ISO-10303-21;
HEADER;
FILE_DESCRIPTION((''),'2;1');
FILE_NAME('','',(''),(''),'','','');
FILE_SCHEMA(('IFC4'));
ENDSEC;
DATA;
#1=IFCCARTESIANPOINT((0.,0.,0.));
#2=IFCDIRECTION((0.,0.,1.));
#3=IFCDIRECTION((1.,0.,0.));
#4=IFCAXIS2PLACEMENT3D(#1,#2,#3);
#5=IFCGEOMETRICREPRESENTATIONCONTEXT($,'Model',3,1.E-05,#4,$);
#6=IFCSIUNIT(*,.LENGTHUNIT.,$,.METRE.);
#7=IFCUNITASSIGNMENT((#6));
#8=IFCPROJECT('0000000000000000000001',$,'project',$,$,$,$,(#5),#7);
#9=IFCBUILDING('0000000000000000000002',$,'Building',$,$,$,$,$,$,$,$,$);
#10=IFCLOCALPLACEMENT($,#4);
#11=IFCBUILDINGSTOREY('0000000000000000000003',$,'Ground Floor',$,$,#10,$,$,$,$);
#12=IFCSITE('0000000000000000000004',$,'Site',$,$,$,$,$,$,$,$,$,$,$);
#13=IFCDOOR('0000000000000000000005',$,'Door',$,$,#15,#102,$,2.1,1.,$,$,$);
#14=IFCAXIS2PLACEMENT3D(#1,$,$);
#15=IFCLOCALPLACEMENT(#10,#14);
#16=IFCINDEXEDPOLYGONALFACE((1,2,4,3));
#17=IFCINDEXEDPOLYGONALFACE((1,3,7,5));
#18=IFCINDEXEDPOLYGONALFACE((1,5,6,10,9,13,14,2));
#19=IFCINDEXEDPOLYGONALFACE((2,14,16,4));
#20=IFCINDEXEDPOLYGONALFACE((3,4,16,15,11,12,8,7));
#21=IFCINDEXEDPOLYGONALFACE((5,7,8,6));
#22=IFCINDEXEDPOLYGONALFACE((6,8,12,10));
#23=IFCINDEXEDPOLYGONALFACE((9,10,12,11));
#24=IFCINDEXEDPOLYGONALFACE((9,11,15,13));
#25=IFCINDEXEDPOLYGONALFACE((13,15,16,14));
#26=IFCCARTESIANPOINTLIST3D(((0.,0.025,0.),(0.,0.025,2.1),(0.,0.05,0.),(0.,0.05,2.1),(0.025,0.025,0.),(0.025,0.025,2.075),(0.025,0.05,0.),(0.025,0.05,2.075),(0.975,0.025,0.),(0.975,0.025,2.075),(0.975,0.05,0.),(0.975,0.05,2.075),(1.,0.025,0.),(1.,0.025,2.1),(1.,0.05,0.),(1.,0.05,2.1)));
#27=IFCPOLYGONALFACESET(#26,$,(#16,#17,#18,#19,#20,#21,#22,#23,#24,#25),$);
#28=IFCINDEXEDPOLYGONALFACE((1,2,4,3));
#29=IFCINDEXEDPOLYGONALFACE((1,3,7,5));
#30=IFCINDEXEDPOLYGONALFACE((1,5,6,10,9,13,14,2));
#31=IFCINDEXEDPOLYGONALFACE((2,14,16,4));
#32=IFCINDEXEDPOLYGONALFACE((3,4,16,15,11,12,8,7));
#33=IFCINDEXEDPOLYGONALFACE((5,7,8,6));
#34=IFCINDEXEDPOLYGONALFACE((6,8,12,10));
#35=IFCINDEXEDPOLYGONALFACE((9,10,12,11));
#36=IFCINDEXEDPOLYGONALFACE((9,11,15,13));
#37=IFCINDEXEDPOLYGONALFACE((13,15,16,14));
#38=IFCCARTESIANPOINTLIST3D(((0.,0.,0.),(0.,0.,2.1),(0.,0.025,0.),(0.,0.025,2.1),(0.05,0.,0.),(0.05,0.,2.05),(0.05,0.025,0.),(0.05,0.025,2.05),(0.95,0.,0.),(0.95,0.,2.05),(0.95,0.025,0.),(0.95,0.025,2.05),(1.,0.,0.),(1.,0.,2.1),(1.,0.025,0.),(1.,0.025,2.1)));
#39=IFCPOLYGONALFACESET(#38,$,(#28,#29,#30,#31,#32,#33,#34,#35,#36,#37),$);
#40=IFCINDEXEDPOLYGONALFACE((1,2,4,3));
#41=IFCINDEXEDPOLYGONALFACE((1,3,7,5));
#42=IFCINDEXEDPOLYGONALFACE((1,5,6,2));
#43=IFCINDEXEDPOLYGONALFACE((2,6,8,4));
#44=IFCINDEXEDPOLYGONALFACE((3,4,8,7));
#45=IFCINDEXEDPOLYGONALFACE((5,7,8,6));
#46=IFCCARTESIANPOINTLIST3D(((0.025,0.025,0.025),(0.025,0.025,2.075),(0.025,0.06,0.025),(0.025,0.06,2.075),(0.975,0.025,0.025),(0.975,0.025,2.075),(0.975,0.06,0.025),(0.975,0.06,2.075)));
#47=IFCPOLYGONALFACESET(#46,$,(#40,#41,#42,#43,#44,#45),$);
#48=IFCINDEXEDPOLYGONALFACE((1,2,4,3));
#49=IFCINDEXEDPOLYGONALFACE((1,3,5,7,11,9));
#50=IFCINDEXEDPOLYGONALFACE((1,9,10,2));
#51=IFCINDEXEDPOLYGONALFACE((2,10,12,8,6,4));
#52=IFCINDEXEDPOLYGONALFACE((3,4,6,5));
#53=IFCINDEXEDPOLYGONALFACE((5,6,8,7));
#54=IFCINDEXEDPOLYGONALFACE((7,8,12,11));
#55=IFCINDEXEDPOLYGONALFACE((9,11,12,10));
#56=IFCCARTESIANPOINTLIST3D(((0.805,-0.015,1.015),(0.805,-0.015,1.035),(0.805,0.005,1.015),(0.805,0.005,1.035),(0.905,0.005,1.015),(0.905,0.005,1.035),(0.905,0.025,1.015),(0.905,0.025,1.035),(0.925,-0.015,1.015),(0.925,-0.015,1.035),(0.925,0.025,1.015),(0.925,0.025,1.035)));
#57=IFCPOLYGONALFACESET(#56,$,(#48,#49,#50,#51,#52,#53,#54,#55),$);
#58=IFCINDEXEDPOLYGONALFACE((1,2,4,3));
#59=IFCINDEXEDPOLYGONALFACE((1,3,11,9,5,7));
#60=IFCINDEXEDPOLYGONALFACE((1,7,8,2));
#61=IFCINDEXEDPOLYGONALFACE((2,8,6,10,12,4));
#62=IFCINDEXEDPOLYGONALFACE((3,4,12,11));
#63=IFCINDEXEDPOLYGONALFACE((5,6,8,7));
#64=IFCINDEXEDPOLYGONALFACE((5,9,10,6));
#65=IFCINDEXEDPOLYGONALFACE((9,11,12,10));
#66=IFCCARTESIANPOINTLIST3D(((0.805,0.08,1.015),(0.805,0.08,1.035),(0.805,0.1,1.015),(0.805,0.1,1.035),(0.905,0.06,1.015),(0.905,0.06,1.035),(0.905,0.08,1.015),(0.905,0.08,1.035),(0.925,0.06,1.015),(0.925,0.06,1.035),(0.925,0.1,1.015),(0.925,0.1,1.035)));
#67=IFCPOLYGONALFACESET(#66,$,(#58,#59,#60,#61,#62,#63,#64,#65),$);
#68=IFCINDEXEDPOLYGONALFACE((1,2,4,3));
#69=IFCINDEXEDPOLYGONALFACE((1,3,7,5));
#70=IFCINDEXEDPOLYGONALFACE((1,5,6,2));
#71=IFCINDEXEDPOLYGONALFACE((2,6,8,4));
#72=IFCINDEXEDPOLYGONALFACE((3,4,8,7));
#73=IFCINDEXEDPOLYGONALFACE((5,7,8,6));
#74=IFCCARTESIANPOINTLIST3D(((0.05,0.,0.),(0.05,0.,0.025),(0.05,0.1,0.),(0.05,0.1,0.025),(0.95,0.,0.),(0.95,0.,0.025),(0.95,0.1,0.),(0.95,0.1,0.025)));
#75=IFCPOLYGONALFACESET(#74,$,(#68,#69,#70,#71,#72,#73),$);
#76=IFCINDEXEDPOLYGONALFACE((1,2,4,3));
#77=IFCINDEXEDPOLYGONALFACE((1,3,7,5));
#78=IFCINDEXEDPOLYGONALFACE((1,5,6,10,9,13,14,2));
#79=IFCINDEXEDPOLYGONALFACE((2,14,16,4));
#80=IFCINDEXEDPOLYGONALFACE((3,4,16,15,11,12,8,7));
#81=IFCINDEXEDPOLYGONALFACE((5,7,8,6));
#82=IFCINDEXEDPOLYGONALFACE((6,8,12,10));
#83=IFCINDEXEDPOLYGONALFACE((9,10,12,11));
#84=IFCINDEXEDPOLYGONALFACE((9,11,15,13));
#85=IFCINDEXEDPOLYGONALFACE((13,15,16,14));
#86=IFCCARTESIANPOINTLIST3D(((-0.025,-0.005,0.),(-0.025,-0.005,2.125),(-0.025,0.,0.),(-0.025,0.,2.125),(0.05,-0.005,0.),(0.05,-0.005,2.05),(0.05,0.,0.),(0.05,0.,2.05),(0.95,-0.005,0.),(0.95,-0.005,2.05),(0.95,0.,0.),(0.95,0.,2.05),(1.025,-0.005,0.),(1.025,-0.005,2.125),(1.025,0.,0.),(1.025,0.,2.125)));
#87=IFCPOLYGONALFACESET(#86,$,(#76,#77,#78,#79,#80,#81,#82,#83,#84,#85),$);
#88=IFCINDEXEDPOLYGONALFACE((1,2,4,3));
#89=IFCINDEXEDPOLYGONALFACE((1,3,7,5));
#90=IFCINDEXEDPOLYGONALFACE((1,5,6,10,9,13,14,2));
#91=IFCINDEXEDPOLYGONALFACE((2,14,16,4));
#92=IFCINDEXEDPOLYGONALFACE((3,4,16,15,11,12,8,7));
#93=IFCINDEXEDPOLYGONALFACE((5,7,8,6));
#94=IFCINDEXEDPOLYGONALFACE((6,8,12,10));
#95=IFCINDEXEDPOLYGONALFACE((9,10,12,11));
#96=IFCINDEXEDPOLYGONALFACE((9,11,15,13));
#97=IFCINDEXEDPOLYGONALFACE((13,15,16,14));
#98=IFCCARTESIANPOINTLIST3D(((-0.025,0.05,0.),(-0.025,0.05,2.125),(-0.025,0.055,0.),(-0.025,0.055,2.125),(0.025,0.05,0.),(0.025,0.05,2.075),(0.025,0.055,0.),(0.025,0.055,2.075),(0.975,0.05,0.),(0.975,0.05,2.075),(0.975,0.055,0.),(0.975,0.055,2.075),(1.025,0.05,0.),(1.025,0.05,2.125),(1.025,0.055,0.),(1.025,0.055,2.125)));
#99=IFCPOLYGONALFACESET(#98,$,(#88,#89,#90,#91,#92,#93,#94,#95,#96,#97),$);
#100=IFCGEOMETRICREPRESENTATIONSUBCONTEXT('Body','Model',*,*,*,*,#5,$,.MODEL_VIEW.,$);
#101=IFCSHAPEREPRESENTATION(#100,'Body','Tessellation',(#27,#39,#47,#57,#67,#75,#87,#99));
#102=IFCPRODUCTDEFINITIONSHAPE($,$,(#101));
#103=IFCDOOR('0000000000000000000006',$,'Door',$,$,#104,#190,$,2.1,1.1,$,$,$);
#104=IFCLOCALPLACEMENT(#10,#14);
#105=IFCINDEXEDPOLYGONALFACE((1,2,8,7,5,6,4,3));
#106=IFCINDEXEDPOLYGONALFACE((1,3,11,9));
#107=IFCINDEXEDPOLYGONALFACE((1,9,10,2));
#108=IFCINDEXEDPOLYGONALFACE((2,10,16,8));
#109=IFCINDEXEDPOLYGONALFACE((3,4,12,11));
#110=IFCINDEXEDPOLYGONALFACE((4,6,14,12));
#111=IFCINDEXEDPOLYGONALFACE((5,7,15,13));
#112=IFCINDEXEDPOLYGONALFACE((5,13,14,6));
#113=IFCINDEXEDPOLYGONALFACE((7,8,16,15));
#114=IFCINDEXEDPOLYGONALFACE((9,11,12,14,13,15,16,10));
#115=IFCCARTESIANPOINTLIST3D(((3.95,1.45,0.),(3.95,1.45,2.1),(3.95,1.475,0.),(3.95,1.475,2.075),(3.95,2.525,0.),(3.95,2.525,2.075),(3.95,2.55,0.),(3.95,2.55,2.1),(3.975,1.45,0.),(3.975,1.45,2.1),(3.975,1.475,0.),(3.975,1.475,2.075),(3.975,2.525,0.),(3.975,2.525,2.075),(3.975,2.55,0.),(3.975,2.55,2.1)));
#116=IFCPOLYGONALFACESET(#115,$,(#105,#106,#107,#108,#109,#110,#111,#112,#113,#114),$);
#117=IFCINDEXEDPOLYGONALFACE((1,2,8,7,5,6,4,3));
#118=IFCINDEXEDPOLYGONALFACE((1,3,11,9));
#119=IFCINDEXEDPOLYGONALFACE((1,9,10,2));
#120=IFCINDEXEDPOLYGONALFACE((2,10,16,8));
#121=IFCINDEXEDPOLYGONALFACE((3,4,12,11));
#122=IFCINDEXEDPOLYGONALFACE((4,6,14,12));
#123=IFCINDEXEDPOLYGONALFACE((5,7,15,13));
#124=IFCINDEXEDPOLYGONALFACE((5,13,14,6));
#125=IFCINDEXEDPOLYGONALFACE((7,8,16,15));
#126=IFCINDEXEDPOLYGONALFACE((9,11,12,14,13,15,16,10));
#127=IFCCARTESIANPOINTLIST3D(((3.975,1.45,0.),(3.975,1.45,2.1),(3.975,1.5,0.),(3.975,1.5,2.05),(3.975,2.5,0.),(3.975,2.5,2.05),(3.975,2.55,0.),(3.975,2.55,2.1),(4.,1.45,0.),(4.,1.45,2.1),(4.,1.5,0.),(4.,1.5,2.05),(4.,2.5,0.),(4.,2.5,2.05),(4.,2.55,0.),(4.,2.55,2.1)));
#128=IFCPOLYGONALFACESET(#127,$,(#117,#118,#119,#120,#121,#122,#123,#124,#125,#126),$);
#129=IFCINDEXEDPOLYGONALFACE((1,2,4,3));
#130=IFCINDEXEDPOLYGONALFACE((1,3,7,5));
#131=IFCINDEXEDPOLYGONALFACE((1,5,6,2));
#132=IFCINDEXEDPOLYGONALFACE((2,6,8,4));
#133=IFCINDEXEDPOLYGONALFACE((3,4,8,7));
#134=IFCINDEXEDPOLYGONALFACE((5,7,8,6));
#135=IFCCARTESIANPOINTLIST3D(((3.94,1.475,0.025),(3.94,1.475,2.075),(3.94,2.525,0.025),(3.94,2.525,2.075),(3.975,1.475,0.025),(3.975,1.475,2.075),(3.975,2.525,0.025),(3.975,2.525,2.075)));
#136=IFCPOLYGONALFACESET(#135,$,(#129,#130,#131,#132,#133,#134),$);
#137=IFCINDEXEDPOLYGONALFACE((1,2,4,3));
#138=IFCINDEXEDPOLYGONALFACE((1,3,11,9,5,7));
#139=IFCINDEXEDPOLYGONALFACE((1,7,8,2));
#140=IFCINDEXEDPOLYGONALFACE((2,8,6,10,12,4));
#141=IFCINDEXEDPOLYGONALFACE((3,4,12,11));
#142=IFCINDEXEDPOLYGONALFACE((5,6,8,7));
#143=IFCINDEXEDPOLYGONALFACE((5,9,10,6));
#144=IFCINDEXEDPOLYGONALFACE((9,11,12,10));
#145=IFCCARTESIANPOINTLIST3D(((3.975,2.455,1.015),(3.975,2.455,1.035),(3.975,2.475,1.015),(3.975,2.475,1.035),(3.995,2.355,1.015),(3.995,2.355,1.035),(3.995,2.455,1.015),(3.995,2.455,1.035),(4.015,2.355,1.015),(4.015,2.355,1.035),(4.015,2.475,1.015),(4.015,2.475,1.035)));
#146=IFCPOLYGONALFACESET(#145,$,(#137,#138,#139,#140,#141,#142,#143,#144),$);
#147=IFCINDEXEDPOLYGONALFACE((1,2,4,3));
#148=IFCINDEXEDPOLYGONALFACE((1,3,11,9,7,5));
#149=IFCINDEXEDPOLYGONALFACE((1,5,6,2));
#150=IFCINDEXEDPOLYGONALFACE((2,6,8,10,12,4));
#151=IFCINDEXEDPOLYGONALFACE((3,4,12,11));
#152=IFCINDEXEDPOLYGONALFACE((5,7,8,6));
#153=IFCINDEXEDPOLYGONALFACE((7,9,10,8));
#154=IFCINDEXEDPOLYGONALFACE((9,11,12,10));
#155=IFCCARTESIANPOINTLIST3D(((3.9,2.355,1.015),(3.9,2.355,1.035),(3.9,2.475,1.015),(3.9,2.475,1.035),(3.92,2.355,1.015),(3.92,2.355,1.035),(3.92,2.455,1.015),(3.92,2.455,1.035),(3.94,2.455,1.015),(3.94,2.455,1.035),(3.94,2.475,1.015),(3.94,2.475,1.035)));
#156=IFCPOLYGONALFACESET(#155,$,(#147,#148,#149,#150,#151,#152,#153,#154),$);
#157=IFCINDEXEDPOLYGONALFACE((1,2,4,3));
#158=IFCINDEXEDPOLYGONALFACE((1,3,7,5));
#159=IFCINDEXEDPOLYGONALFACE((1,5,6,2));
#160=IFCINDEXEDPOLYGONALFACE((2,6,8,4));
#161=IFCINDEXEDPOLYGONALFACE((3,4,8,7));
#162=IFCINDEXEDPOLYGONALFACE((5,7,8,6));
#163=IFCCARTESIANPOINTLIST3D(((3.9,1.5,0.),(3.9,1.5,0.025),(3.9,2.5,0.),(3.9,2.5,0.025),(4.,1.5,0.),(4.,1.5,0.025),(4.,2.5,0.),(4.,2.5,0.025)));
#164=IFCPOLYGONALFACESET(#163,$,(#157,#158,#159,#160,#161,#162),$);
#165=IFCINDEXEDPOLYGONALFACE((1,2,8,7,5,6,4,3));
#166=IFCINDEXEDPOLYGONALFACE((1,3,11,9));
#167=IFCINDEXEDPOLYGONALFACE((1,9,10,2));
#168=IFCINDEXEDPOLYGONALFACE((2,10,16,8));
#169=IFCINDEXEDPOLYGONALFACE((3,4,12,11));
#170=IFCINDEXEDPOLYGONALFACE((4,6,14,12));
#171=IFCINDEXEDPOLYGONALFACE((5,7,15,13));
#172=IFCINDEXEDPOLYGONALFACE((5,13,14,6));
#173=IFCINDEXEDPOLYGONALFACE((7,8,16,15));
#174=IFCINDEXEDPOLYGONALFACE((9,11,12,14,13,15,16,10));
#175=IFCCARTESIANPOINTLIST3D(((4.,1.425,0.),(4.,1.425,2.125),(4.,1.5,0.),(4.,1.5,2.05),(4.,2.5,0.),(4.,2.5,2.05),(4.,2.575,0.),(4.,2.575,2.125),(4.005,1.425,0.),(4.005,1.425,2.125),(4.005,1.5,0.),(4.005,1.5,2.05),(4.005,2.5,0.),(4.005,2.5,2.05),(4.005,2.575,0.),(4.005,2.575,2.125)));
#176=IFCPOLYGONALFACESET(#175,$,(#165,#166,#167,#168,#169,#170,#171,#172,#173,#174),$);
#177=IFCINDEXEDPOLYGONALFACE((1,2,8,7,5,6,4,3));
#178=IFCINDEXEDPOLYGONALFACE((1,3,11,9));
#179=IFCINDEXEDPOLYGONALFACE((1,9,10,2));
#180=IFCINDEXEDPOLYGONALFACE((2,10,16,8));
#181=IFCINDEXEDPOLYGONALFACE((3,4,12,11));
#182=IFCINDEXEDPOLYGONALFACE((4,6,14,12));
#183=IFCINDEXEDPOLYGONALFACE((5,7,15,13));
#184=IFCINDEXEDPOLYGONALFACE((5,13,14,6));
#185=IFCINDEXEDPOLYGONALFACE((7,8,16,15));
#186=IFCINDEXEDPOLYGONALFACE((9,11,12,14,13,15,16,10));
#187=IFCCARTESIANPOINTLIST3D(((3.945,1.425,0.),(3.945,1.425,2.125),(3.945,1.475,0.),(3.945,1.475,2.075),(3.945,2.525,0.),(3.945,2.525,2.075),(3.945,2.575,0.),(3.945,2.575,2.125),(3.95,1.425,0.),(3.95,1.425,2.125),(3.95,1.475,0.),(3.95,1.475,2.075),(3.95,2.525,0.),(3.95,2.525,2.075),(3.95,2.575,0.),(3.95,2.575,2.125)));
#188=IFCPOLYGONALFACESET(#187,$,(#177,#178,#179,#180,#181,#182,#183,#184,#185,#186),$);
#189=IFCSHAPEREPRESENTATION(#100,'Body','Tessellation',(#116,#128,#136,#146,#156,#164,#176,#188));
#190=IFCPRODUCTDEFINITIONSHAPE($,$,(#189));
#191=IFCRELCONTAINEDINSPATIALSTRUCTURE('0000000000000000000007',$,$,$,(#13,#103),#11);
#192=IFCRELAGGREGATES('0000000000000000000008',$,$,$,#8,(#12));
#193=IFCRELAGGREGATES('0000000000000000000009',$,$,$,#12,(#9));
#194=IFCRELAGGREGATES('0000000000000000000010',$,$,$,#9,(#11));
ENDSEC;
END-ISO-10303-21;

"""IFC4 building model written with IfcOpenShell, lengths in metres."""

from ifc_helpers import new_model, si_unit, frame, origin_with_axes, place, context, subcontext, project, spatial, line, indexed_curve, outline, extrude, element, save


model = new_model("IFC4")

# Units and contexts
model_context = context("Model", 3, precision=1e-05, world=origin_with_axes())
body_context = subcontext(model_context, "Body", "Model", "MODEL_VIEW")
ifc_project = project(units=[si_unit("LENGTHUNIT", "METRE")], contexts=[model_context])

# Site, building, storey
site = spatial("IfcSite", under=ifc_project, Name="Site")
building = spatial("IfcBuilding", under=site, Name="Building")
storey_placement = place(None, origin_with_axes())
storey = spatial("IfcBuildingStorey", under=building, at=storey_placement, Name="Ground Floor")

# Doors
door_1_placement = place(storey_placement, origin_with_axes())
element("IfcDoor", 1, at=door_1_placement, inside=storey, Name="Door", OverallHeight=2.1, OverallWidth=1.0, context=body_context, shape_type="SweptSolid", body=[
    extrude(outline(indexed_curve([(0.0, 0.0), (0.0, 2.1), (1.0, 2.1), (1.0, 0.0), (0.975, 0.0), (0.975, 2.075), (0.025, 2.075), (0.025, 0.0)], segments=[line(1, 2, 3, 4, 5, 6, 7, 8, 1)])), frame((0.0, 0.025, 0.0), z_axis=(0.0, -1.0, 0.0), x_axis=(1.0, 0.0, 0.0)), (0.0, 0.0, -1.0), 0.025),
    extrude(outline(indexed_curve([(0.0, 0.0), (0.0, 2.1), (1.0, 2.1), (1.0, 0.0), (0.95, 0.0), (0.95, 2.05), (0.05, 2.05), (0.05, 0.0)], segments=[line(1, 2, 3, 4, 5, 6, 7, 8, 1)])), frame((0.0, 0.0, 0.0), z_axis=(0.0, -1.0, 0.0), x_axis=(1.0, 0.0, 0.0)), (0.0, 0.0, -1.0), 0.025),
    extrude(outline(indexed_curve([(0.0, 0.0), (0.95, 0.0), (0.95, 0.035), (0.0, 0.035)], segments=[line(1, 2, 3, 4, 1)])), frame((0.025, 0.025, 0.025), z_axis=(0.0, 0.0, 1.0), x_axis=(1.0, 0.0, 0.0)), (0.0, 0.0, 1.0), 2.05),
    extrude(outline(indexed_curve([(0.0, 0.0), (0.0, -0.04), (-0.12, -0.04), (-0.12, -0.02), (-0.02, -0.02), (-0.02, 0.0)], segments=[line(1, 2, 3, 4, 5, 6, 1)])), frame((0.925, 0.025, 1.015), z_axis=(0.0, 0.0, 1.0), x_axis=(1.0, 0.0, 0.0)), (0.0, 0.0, 1.0), 0.02),
    extrude(outline(indexed_curve([(0.0, 0.0), (0.0, 0.04), (-0.12, 0.04), (-0.12, 0.02), (-0.02, 0.02), (-0.02, 0.0)], segments=[line(1, 2, 3, 4, 5, 6, 1)])), frame((0.925, 0.06, 1.015), z_axis=(0.0, 0.0, 1.0), x_axis=(1.0, 0.0, 0.0)), (0.0, 0.0, 1.0), 0.02),
    extrude(outline(indexed_curve([(0.0, 0.0), (0.9, 0.0), (0.9, 0.1), (0.0, 0.1)], segments=[line(1, 2, 3, 4, 1)])), frame((0.05, 0.0, 0.0), z_axis=(0.0, 0.0, 1.0), x_axis=(1.0, 0.0, 0.0)), (0.0, 0.0, 1.0), 0.025),
    extrude(outline(indexed_curve([(0.0, 0.0), (0.0, 2.125), (1.05, 2.125), (1.05, 0.0), (0.975, 0.0), (0.975, 2.05), (0.075, 2.05), (0.075, 0.0)], segments=[line(1, 2, 3, 4, 5, 6, 7, 8, 1)])), frame((-0.025, -0.005, 0.0), z_axis=(0.0, -1.0, 0.0), x_axis=(1.0, 0.0, 0.0)), (0.0, 0.0, -1.0), 0.005),
    extrude(outline(indexed_curve([(0.0, 0.0), (0.0, 2.125), (1.05, 2.125), (1.05, 0.0), (1.0, 0.0), (1.0, 2.075), (0.05, 2.075), (0.05, 0.0)], segments=[line(1, 2, 3, 4, 5, 6, 7, 8, 1)])), frame((-0.025, 0.05, 0.0), z_axis=(0.0, -1.0, 0.0), x_axis=(1.0, 0.0, 0.0)), (0.0, 0.0, -1.0), 0.005),
])
door_2_placement = place(storey_placement, frame((4.0, 1.45, 0.0), z_axis=(0.0, 0.0, 1.0), x_axis=(0.0, 1.0, 0.0)))
element("IfcDoor", 2, at=door_2_placement, inside=storey, Name="Door", OverallHeight=2.1, OverallWidth=1.1, context=body_context, shape_type="SweptSolid", body=[
    extrude(outline(indexed_curve([(0.0, 0.0), (0.0, 2.1), (1.1, 2.1), (1.1, 0.0), (1.075, 0.0), (1.075, 2.075), (0.025, 2.075), (0.025, 0.0)], segments=[line(1, 2, 3, 4, 5, 6, 7, 8, 1)])), frame((0.0, 0.025, 0.0), z_axis=(0.0, -1.0, 0.0), x_axis=(1.0, 0.0, 0.0)), (0.0, 0.0, -1.0), 0.025),
    extrude(outline(indexed_curve([(0.0, 0.0), (0.0, 2.1), (1.1, 2.1), (1.1, 0.0), (1.05, 0.0), (1.05, 2.05), (0.05, 2.05), (0.05, 0.0)], segments=[line(1, 2, 3, 4, 5, 6, 7, 8, 1)])), frame((0.0, 0.0, 0.0), z_axis=(0.0, -1.0, 0.0), x_axis=(1.0, 0.0, 0.0)), (0.0, 0.0, -1.0), 0.025),
    extrude(outline(indexed_curve([(0.0, 0.0), (1.05, 0.0), (1.05, 0.035), (0.0, 0.035)], segments=[line(1, 2, 3, 4, 1)])), frame((0.025, 0.025, 0.025), z_axis=(0.0, 0.0, 1.0), x_axis=(1.0, 0.0, 0.0)), (0.0, 0.0, 1.0), 2.05),
    extrude(outline(indexed_curve([(0.0, 0.0), (0.0, -0.04), (-0.12, -0.04), (-0.12, -0.02), (-0.02, -0.02), (-0.02, 0.0)], segments=[line(1, 2, 3, 4, 5, 6, 1)])), frame((1.025, 0.025, 1.015), z_axis=(0.0, 0.0, 1.0), x_axis=(1.0, 0.0, 0.0)), (0.0, 0.0, 1.0), 0.02),
    extrude(outline(indexed_curve([(0.0, 0.0), (0.0, 0.04), (-0.12, 0.04), (-0.12, 0.02), (-0.02, 0.02), (-0.02, 0.0)], segments=[line(1, 2, 3, 4, 5, 6, 1)])), frame((1.025, 0.06, 1.015), z_axis=(0.0, 0.0, 1.0), x_axis=(1.0, 0.0, 0.0)), (0.0, 0.0, 1.0), 0.02),
    extrude(outline(indexed_curve([(0.0, 0.0), (1.0, 0.0), (1.0, 0.1), (0.0, 0.1)], segments=[line(1, 2, 3, 4, 1)])), frame((0.05, 0.0, 0.0), z_axis=(0.0, 0.0, 1.0), x_axis=(1.0, 0.0, 0.0)), (0.0, 0.0, 1.0), 0.025),
    extrude(outline(indexed_curve([(0.0, 0.0), (0.0, 2.125), (1.15, 2.125), (1.15, 0.0), (1.075, 0.0), (1.075, 2.05), (0.075, 2.05), (0.075, 0.0)], segments=[line(1, 2, 3, 4, 5, 6, 7, 8, 1)])), frame((-0.025, -0.005, 0.0), z_axis=(0.0, -1.0, 0.0), x_axis=(1.0, 0.0, 0.0)), (0.0, 0.0, -1.0), 0.005),
    extrude(outline(indexed_curve([(0.0, 0.0), (0.0, 2.125), (1.15, 2.125), (1.15, 0.0), (1.1, 0.0), (1.1, 2.075), (0.05, 2.075), (0.05, 0.0)], segments=[line(1, 2, 3, 4, 5, 6, 7, 8, 1)])), frame((-0.025, 0.05, 0.0), z_axis=(0.0, -1.0, 0.0), x_axis=(1.0, 0.0, 0.0)), (0.0, 0.0, -1.0), 0.005),
])

save(model, "model.ifc")
